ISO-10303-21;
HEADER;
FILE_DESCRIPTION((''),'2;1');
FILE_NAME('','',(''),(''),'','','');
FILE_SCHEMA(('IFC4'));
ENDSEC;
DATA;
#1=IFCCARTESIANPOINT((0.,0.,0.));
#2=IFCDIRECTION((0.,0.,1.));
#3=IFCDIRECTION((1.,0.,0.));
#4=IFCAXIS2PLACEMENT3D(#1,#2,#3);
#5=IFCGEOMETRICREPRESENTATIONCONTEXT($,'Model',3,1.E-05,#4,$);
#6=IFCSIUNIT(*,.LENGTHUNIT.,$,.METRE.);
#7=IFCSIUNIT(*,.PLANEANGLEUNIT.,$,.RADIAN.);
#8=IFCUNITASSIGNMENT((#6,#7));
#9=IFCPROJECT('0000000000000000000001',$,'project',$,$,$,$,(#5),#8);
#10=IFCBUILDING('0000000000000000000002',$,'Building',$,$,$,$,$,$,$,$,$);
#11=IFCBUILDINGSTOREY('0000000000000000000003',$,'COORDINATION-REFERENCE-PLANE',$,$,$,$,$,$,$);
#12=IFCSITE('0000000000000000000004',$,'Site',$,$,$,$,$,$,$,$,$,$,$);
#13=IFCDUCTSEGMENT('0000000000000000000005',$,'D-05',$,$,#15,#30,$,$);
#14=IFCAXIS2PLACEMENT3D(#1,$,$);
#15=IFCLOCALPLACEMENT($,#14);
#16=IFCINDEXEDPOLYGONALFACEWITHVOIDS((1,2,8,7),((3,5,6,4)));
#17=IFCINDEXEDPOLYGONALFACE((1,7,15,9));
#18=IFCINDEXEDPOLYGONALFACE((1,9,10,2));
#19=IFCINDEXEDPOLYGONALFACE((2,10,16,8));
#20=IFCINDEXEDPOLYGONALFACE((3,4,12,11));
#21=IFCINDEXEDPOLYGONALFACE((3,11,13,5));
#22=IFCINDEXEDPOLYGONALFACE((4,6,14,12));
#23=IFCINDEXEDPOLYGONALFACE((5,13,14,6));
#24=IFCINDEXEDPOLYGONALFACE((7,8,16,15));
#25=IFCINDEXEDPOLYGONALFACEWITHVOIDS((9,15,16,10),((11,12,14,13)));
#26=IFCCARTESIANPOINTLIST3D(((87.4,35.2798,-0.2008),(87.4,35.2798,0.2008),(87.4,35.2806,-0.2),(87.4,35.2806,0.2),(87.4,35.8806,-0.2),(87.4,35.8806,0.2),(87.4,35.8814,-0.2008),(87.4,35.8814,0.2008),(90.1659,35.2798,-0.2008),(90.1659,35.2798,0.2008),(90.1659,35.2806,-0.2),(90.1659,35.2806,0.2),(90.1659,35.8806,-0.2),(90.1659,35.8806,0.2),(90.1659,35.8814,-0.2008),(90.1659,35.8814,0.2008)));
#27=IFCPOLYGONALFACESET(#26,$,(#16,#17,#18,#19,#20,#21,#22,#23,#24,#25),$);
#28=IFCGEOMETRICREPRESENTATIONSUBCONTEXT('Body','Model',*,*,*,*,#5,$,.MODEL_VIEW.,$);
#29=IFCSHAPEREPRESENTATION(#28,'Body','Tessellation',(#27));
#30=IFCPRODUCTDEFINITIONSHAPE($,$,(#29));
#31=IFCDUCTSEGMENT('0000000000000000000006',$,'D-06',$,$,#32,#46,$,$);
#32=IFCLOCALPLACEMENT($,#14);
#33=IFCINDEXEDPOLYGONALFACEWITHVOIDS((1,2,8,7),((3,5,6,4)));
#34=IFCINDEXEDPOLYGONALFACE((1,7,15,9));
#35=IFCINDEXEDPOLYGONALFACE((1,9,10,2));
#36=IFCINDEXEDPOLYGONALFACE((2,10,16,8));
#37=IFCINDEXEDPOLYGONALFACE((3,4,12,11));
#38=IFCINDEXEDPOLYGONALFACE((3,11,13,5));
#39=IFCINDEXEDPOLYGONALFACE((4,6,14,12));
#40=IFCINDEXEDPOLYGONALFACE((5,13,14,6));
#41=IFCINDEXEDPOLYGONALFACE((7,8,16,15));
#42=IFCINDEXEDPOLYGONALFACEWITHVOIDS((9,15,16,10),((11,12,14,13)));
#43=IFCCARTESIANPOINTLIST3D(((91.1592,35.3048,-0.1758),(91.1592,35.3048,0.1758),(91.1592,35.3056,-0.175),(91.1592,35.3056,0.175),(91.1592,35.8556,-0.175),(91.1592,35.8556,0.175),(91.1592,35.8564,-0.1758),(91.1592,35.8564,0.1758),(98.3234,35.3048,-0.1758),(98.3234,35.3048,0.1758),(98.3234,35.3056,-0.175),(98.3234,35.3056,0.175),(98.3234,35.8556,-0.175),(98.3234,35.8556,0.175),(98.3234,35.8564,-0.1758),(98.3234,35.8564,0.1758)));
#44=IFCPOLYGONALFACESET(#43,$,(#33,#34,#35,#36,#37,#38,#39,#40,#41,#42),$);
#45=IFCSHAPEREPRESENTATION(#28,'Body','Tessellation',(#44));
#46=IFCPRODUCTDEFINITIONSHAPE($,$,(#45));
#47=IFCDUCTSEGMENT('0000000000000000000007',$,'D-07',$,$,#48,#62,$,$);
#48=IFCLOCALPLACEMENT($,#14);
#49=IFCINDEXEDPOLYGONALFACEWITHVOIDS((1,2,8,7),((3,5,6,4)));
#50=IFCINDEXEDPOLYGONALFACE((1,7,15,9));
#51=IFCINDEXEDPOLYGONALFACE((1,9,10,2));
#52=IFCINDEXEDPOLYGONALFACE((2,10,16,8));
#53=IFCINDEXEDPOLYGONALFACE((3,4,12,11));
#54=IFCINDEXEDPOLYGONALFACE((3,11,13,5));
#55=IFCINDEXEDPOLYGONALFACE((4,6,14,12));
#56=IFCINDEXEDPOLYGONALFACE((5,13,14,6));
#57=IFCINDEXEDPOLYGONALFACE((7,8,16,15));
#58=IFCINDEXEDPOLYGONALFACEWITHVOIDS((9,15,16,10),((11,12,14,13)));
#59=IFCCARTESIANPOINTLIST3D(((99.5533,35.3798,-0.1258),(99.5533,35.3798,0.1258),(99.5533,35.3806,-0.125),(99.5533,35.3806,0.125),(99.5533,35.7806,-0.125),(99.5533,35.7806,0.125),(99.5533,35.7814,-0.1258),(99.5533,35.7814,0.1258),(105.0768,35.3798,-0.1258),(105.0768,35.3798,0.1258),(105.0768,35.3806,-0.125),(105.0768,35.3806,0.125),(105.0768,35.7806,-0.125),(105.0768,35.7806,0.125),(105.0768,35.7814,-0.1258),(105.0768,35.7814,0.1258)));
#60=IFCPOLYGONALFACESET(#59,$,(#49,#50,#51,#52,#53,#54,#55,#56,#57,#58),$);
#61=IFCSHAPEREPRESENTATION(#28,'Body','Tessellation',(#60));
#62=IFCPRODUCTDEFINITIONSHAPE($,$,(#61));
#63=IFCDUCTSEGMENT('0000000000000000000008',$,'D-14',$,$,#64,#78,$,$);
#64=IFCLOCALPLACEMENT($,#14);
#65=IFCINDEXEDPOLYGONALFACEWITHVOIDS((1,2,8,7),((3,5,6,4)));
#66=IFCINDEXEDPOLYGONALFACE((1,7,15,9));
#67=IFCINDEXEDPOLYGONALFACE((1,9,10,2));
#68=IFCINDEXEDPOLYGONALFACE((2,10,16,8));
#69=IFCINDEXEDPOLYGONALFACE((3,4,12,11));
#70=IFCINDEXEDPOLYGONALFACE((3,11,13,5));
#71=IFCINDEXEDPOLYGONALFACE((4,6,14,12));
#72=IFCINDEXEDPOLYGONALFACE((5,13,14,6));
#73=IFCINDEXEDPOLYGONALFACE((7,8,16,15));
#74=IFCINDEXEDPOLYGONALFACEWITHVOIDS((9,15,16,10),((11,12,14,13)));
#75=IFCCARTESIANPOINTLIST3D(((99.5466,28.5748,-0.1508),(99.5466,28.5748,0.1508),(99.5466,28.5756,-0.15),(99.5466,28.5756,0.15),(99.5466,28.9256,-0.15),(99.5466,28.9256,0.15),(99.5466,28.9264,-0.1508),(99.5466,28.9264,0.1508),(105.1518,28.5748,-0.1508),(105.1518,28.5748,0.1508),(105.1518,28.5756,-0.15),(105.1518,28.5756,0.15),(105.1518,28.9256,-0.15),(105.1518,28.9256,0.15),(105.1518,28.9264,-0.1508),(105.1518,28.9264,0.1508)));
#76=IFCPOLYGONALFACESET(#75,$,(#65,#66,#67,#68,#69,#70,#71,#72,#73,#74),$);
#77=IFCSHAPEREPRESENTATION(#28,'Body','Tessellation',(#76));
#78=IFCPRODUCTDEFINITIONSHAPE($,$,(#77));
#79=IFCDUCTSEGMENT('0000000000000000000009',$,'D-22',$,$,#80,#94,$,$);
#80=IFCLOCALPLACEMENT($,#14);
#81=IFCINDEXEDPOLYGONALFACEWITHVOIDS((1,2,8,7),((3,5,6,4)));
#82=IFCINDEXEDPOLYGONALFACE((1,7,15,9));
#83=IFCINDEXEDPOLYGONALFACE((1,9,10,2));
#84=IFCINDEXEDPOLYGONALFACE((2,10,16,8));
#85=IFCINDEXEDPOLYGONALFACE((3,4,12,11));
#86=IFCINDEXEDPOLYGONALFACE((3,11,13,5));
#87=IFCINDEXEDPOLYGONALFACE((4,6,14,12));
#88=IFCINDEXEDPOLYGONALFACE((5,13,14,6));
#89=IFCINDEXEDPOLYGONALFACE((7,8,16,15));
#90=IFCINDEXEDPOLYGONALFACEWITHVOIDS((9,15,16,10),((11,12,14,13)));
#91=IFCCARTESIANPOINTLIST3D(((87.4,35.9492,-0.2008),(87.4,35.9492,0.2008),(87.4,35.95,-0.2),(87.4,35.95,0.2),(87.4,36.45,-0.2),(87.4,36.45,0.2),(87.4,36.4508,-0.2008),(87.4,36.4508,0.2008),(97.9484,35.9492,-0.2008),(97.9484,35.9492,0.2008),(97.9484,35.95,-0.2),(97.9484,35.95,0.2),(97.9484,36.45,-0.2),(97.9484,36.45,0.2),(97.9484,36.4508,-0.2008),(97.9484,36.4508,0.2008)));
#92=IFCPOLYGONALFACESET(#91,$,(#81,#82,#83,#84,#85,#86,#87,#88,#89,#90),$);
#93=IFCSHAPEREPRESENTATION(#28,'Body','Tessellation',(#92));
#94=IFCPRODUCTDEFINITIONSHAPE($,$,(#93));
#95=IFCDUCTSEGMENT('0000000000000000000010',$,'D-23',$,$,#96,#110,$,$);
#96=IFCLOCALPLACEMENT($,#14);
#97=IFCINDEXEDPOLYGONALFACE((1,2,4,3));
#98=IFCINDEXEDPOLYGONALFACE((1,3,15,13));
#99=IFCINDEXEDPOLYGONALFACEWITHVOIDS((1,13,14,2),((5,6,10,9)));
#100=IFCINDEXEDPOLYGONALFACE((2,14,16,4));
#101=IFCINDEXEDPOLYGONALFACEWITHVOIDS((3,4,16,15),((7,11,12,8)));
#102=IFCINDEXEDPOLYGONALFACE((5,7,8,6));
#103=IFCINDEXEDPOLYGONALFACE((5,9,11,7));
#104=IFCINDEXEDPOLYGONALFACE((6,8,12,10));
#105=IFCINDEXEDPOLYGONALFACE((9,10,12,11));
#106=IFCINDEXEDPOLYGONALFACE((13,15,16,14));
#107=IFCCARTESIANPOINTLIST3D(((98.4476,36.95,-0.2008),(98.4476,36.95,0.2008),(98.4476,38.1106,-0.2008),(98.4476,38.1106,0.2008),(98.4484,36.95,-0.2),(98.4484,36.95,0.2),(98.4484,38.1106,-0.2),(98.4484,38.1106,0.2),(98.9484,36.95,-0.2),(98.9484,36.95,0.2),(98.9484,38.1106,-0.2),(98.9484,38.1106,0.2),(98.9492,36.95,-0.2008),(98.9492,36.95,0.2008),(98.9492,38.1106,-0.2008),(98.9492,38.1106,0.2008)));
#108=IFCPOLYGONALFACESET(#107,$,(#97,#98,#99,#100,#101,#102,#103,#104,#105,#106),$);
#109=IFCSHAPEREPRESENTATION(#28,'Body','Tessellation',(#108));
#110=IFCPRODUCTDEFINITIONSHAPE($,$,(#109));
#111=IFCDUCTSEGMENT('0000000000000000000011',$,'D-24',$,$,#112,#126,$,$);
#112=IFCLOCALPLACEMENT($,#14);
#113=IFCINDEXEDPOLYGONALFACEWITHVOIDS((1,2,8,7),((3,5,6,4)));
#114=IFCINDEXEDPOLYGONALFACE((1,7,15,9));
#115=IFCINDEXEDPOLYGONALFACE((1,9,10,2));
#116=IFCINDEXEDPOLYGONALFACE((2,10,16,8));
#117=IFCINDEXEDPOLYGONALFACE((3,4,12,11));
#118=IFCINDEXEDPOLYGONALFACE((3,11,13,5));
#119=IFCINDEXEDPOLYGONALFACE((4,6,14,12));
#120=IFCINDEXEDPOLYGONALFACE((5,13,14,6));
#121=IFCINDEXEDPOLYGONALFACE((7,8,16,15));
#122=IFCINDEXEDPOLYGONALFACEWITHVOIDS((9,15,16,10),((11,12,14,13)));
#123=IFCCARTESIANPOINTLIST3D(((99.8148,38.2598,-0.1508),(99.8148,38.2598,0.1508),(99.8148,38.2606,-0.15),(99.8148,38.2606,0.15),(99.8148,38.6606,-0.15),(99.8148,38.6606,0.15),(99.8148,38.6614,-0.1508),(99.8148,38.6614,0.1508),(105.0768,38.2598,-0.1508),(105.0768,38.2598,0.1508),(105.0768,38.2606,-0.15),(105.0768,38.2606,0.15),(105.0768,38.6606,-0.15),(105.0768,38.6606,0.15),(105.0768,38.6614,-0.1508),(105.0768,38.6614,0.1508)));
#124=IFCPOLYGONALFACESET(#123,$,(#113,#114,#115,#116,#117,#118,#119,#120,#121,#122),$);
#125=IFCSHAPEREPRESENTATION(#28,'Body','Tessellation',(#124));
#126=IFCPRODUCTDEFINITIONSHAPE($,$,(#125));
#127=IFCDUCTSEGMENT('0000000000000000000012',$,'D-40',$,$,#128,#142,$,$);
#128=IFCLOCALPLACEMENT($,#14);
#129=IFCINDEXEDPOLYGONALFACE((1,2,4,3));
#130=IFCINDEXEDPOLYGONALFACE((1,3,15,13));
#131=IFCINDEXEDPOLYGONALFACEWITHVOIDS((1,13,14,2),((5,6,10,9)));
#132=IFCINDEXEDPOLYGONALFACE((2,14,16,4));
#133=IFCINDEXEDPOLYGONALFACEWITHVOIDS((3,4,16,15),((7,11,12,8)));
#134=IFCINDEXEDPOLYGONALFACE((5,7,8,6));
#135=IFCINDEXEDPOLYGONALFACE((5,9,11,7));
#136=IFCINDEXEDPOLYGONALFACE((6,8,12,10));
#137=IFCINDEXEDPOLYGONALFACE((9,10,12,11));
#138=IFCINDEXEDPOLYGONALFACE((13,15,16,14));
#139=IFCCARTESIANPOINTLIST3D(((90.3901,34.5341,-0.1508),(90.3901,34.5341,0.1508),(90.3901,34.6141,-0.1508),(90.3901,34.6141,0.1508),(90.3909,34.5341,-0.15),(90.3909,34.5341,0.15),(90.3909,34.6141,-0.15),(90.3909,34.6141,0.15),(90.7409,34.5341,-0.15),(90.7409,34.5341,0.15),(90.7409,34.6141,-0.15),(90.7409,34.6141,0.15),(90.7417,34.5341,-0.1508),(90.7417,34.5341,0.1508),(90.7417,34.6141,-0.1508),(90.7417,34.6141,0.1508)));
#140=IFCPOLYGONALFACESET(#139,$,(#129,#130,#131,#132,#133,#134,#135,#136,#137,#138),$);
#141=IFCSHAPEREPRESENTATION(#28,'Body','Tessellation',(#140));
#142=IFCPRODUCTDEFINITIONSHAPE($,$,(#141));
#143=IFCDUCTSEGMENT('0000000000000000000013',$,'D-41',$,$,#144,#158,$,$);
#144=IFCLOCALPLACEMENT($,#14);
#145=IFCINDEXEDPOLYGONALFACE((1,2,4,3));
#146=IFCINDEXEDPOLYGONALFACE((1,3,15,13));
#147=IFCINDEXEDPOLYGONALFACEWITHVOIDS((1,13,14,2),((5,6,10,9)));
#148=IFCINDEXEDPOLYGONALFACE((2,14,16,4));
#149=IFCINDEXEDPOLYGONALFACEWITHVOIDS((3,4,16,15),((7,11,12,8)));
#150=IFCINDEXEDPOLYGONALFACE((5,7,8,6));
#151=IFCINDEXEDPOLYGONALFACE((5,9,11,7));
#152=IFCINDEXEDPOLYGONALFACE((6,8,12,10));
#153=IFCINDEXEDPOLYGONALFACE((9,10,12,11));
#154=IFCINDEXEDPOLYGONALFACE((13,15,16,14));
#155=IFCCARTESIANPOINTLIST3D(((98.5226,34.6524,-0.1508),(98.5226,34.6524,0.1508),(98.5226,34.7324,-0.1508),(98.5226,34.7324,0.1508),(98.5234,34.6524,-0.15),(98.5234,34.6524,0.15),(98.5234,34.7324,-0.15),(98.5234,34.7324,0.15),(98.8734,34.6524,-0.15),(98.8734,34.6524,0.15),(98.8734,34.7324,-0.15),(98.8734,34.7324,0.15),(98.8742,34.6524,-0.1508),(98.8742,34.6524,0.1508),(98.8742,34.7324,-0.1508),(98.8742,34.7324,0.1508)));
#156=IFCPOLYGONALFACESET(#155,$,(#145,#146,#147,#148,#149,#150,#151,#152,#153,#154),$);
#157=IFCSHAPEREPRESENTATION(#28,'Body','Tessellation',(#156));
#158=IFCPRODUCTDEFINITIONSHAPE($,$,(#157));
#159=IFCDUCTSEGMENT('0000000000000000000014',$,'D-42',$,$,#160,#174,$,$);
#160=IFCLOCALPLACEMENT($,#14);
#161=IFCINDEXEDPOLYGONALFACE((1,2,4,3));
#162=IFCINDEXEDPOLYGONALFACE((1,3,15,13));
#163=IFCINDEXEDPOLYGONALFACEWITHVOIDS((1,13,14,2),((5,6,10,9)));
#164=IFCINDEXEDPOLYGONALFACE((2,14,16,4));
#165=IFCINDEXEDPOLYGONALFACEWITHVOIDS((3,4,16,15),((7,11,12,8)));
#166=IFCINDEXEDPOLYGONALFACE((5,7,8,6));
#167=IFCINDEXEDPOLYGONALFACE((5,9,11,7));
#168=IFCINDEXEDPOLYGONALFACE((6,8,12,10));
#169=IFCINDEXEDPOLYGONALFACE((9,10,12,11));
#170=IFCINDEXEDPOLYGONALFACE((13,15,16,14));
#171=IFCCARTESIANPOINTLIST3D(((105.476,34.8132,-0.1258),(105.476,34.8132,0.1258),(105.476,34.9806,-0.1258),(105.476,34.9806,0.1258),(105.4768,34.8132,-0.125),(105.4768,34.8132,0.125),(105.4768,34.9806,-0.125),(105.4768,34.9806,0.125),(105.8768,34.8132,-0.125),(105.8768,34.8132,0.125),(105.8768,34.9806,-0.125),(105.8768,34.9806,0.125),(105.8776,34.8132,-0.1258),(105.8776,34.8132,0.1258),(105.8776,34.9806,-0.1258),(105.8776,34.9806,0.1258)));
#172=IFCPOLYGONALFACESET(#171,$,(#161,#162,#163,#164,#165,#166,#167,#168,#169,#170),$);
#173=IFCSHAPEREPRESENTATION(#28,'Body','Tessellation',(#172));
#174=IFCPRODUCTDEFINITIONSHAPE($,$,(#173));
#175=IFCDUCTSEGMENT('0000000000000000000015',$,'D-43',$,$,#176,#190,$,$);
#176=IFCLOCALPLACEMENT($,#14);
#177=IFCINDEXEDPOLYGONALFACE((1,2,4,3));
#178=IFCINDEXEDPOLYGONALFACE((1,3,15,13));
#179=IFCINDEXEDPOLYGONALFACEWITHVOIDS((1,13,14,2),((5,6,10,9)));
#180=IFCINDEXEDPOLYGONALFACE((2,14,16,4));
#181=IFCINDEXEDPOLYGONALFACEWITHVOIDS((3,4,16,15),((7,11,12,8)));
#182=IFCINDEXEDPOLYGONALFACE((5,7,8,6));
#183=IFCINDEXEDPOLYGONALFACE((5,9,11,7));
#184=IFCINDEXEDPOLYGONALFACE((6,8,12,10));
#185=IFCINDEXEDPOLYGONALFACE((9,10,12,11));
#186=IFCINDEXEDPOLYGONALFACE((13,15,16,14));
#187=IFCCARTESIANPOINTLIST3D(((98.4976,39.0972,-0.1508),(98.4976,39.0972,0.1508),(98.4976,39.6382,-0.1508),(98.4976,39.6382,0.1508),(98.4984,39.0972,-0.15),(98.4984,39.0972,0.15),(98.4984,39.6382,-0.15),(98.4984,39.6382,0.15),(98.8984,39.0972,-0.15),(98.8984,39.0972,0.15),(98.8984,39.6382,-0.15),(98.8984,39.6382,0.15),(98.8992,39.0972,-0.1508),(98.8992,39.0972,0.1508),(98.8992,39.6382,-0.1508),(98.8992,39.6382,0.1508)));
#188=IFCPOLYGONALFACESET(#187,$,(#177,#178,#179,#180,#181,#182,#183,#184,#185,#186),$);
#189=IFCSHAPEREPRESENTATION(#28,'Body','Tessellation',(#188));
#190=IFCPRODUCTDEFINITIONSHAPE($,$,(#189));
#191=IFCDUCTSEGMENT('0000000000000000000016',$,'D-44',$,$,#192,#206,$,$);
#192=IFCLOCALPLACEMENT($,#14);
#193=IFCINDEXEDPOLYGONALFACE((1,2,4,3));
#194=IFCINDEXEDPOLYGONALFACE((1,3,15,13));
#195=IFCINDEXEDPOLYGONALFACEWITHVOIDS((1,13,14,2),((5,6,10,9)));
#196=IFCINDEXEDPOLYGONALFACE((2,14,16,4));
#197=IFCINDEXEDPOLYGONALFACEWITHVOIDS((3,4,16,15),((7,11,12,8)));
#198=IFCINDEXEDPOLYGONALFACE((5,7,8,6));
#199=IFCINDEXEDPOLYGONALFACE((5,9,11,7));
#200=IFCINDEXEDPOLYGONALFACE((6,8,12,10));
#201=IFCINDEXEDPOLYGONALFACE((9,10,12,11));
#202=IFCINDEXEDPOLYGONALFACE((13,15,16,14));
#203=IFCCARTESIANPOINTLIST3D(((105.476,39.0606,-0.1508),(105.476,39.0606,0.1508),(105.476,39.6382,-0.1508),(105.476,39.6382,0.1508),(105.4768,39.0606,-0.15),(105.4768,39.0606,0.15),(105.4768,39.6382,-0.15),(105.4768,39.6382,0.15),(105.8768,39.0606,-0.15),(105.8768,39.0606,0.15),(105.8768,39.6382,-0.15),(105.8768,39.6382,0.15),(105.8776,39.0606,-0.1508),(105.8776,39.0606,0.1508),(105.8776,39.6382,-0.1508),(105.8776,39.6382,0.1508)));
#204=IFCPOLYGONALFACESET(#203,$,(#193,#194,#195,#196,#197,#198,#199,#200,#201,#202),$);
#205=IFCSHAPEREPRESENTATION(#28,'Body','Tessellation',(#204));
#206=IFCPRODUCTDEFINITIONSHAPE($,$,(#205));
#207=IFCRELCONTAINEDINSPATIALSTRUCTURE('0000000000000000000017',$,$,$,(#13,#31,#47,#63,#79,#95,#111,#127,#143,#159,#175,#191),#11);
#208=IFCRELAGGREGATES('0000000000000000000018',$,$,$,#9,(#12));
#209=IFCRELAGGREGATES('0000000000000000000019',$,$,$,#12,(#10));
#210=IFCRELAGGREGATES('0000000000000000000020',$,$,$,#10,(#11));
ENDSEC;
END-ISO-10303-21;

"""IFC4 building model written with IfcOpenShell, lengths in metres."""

from ifc_helpers import new_model, si_unit, frame, origin, origin_with_axes, place, context, subcontext, project, spatial, hollow_rectangle, extrude, element, save


model = new_model("IFC4")

# Units and contexts
model_context = context("Model", 3, precision=1e-05, world=origin_with_axes())
body_context_1 = subcontext(model_context, "Body", "Model", "MODEL_VIEW")
ifc_project = project(units=[si_unit("LENGTHUNIT", "METRE"), si_unit("PLANEANGLEUNIT", "RADIAN")], contexts=[model_context])

# Site, building, storey
site = spatial("IfcSite", under=ifc_project, Name="Site")
building = spatial("IfcBuilding", under=site, Name="Building")
storey = spatial("IfcBuildingStorey", under=building, Name="COORDINATION-REFERENCE-PLANE")

# Duct segments
duct_segment_1_placement = place(None, frame((87.4, 35.5806, 0.0), z_axis=(1.0, 0.0, 0.0), x_axis=(0.0, 1.0, 0.0)))
element("IfcDuctSegment", 1, at=duct_segment_1_placement, inside=storey, Name="D-05", context=body_context_1, shape_type="SweptSolid", body=[
    extrude(hollow_rectangle(XDim=0.6016, YDim=0.4016, WallThickness=0.0008), origin(), (0.0, 0.0, 1.0), 2.7659),
])
duct_segment_2_placement = place(None, frame((91.1592, 35.5806, 0.0), z_axis=(1.0, 0.0, 0.0), x_axis=(0.0, 1.0, 0.0)))
element("IfcDuctSegment", 2, at=duct_segment_2_placement, inside=storey, Name="D-06", context=body_context_1, shape_type="SweptSolid", body=[
    extrude(hollow_rectangle(XDim=0.5516, YDim=0.3516, WallThickness=0.0008), origin(), (0.0, 0.0, 1.0), 7.1642),
])
duct_segment_3_placement = place(None, frame((99.5533, 35.5806, 0.0), z_axis=(1.0, 0.0, 0.0), x_axis=(0.0, 1.0, 0.0)))
element("IfcDuctSegment", 3, at=duct_segment_3_placement, inside=storey, Name="D-07", context=body_context_1, shape_type="SweptSolid", body=[
    extrude(hollow_rectangle(XDim=0.4016, YDim=0.2516, WallThickness=0.0008), origin(), (0.0, 0.0, 1.0), 5.5234),
])
duct_segment_4_placement = place(None, frame((99.5466, 28.7506, 0.0), z_axis=(1.0, 0.0, 0.0), x_axis=(0.0, 1.0, 0.0)))
element("IfcDuctSegment", 4, at=duct_segment_4_placement, inside=storey, Name="D-14", context=body_context_1, shape_type="SweptSolid", body=[
    extrude(hollow_rectangle(XDim=0.3516, YDim=0.3016, WallThickness=0.0008), origin(), (0.0, 0.0, 1.0), 5.6051),
])
duct_segment_5_placement = place(None, frame((87.4, 36.2, 0.0), z_axis=(1.0, 0.0, 0.0), x_axis=(0.0, 1.0, 0.0)))
element("IfcDuctSegment", 5, at=duct_segment_5_placement, inside=storey, Name="D-22", context=body_context_1, shape_type="SweptSolid", body=[
    extrude(hollow_rectangle(XDim=0.5016, YDim=0.4016, WallThickness=0.0008), origin(), (0.0, 0.0, 1.0), 10.5484),
])
duct_segment_6_placement = place(None, frame((98.6984, 36.95, 0.0), z_axis=(0.0, 1.0, 0.0), x_axis=(1.0, 0.0, 0.0)))
element("IfcDuctSegment", 6, at=duct_segment_6_placement, inside=storey, Name="D-23", context=body_context_1, shape_type="SweptSolid", body=[
    extrude(hollow_rectangle(XDim=0.5016, YDim=0.4016, WallThickness=0.0008), origin(), (0.0, 0.0, 1.0), 1.1606),
])
duct_segment_7_placement = place(None, frame((99.8148, 38.4606, 0.0), z_axis=(1.0, 0.0, 0.0), x_axis=(0.0, 1.0, 0.0)))
element("IfcDuctSegment", 7, at=duct_segment_7_placement, inside=storey, Name="D-24", context=body_context_1, shape_type="SweptSolid", body=[
    extrude(hollow_rectangle(XDim=0.4016, YDim=0.3016, WallThickness=0.0008), origin(), (0.0, 0.0, 1.0), 5.2619),
])
for number, where, z_axis, x_axis, name in (
    (8, (90.5659, 34.5341, 0.0), (0.0, 1.0, 0.0), (1.0, 0.0, 0.0), "D-40"),
    (9, (98.6984, 34.6524, 0.0), (0.0, 1.0, 0.0), (1.0, 0.0, 0.0), "D-41"),
):
    element("IfcDuctSegment", number, at=place(None, frame(where, z_axis=z_axis, x_axis=x_axis)), inside=storey, Name=name, context=body_context_1, shape_type="SweptSolid", body=[
        extrude(hollow_rectangle(XDim=0.3516, YDim=0.3016, WallThickness=0.0008), origin(), (0.0, 0.0, 1.0), 0.08),
    ])
duct_segment_8_placement = place(None, frame((105.6768, 34.8132, 0.0), z_axis=(0.0, 1.0, 0.0), x_axis=(1.0, 0.0, 0.0)))
element("IfcDuctSegment", 10, at=duct_segment_8_placement, inside=storey, Name="D-42", context=body_context_1, shape_type="SweptSolid", body=[
    extrude(hollow_rectangle(XDim=0.4016, YDim=0.2516, WallThickness=0.0008), origin(), (0.0, 0.0, 1.0), 0.1673),
])
duct_segment_9_placement = place(None, frame((98.6984, 39.0972, 0.0), z_axis=(0.0, 1.0, 0.0), x_axis=(1.0, 0.0, 0.0)))
element("IfcDuctSegment", 11, at=duct_segment_9_placement, inside=storey, Name="D-43", context=body_context_1, shape_type="SweptSolid", body=[
    extrude(hollow_rectangle(XDim=0.4016, YDim=0.3016, WallThickness=0.0008), origin(), (0.0, 0.0, 1.0), 0.541),
])
duct_segment_10_placement = place(None, frame((105.6768, 39.0606, 0.0), z_axis=(0.0, 1.0, 0.0), x_axis=(1.0, 0.0, 0.0)))
element("IfcDuctSegment", 12, at=duct_segment_10_placement, inside=storey, Name="D-44", context=body_context_1, shape_type="SweptSolid", body=[
    extrude(hollow_rectangle(XDim=0.4016, YDim=0.3016, WallThickness=0.0008), origin(), (0.0, 0.0, 1.0), 0.5776),
])

save(model, "model.ifc")
